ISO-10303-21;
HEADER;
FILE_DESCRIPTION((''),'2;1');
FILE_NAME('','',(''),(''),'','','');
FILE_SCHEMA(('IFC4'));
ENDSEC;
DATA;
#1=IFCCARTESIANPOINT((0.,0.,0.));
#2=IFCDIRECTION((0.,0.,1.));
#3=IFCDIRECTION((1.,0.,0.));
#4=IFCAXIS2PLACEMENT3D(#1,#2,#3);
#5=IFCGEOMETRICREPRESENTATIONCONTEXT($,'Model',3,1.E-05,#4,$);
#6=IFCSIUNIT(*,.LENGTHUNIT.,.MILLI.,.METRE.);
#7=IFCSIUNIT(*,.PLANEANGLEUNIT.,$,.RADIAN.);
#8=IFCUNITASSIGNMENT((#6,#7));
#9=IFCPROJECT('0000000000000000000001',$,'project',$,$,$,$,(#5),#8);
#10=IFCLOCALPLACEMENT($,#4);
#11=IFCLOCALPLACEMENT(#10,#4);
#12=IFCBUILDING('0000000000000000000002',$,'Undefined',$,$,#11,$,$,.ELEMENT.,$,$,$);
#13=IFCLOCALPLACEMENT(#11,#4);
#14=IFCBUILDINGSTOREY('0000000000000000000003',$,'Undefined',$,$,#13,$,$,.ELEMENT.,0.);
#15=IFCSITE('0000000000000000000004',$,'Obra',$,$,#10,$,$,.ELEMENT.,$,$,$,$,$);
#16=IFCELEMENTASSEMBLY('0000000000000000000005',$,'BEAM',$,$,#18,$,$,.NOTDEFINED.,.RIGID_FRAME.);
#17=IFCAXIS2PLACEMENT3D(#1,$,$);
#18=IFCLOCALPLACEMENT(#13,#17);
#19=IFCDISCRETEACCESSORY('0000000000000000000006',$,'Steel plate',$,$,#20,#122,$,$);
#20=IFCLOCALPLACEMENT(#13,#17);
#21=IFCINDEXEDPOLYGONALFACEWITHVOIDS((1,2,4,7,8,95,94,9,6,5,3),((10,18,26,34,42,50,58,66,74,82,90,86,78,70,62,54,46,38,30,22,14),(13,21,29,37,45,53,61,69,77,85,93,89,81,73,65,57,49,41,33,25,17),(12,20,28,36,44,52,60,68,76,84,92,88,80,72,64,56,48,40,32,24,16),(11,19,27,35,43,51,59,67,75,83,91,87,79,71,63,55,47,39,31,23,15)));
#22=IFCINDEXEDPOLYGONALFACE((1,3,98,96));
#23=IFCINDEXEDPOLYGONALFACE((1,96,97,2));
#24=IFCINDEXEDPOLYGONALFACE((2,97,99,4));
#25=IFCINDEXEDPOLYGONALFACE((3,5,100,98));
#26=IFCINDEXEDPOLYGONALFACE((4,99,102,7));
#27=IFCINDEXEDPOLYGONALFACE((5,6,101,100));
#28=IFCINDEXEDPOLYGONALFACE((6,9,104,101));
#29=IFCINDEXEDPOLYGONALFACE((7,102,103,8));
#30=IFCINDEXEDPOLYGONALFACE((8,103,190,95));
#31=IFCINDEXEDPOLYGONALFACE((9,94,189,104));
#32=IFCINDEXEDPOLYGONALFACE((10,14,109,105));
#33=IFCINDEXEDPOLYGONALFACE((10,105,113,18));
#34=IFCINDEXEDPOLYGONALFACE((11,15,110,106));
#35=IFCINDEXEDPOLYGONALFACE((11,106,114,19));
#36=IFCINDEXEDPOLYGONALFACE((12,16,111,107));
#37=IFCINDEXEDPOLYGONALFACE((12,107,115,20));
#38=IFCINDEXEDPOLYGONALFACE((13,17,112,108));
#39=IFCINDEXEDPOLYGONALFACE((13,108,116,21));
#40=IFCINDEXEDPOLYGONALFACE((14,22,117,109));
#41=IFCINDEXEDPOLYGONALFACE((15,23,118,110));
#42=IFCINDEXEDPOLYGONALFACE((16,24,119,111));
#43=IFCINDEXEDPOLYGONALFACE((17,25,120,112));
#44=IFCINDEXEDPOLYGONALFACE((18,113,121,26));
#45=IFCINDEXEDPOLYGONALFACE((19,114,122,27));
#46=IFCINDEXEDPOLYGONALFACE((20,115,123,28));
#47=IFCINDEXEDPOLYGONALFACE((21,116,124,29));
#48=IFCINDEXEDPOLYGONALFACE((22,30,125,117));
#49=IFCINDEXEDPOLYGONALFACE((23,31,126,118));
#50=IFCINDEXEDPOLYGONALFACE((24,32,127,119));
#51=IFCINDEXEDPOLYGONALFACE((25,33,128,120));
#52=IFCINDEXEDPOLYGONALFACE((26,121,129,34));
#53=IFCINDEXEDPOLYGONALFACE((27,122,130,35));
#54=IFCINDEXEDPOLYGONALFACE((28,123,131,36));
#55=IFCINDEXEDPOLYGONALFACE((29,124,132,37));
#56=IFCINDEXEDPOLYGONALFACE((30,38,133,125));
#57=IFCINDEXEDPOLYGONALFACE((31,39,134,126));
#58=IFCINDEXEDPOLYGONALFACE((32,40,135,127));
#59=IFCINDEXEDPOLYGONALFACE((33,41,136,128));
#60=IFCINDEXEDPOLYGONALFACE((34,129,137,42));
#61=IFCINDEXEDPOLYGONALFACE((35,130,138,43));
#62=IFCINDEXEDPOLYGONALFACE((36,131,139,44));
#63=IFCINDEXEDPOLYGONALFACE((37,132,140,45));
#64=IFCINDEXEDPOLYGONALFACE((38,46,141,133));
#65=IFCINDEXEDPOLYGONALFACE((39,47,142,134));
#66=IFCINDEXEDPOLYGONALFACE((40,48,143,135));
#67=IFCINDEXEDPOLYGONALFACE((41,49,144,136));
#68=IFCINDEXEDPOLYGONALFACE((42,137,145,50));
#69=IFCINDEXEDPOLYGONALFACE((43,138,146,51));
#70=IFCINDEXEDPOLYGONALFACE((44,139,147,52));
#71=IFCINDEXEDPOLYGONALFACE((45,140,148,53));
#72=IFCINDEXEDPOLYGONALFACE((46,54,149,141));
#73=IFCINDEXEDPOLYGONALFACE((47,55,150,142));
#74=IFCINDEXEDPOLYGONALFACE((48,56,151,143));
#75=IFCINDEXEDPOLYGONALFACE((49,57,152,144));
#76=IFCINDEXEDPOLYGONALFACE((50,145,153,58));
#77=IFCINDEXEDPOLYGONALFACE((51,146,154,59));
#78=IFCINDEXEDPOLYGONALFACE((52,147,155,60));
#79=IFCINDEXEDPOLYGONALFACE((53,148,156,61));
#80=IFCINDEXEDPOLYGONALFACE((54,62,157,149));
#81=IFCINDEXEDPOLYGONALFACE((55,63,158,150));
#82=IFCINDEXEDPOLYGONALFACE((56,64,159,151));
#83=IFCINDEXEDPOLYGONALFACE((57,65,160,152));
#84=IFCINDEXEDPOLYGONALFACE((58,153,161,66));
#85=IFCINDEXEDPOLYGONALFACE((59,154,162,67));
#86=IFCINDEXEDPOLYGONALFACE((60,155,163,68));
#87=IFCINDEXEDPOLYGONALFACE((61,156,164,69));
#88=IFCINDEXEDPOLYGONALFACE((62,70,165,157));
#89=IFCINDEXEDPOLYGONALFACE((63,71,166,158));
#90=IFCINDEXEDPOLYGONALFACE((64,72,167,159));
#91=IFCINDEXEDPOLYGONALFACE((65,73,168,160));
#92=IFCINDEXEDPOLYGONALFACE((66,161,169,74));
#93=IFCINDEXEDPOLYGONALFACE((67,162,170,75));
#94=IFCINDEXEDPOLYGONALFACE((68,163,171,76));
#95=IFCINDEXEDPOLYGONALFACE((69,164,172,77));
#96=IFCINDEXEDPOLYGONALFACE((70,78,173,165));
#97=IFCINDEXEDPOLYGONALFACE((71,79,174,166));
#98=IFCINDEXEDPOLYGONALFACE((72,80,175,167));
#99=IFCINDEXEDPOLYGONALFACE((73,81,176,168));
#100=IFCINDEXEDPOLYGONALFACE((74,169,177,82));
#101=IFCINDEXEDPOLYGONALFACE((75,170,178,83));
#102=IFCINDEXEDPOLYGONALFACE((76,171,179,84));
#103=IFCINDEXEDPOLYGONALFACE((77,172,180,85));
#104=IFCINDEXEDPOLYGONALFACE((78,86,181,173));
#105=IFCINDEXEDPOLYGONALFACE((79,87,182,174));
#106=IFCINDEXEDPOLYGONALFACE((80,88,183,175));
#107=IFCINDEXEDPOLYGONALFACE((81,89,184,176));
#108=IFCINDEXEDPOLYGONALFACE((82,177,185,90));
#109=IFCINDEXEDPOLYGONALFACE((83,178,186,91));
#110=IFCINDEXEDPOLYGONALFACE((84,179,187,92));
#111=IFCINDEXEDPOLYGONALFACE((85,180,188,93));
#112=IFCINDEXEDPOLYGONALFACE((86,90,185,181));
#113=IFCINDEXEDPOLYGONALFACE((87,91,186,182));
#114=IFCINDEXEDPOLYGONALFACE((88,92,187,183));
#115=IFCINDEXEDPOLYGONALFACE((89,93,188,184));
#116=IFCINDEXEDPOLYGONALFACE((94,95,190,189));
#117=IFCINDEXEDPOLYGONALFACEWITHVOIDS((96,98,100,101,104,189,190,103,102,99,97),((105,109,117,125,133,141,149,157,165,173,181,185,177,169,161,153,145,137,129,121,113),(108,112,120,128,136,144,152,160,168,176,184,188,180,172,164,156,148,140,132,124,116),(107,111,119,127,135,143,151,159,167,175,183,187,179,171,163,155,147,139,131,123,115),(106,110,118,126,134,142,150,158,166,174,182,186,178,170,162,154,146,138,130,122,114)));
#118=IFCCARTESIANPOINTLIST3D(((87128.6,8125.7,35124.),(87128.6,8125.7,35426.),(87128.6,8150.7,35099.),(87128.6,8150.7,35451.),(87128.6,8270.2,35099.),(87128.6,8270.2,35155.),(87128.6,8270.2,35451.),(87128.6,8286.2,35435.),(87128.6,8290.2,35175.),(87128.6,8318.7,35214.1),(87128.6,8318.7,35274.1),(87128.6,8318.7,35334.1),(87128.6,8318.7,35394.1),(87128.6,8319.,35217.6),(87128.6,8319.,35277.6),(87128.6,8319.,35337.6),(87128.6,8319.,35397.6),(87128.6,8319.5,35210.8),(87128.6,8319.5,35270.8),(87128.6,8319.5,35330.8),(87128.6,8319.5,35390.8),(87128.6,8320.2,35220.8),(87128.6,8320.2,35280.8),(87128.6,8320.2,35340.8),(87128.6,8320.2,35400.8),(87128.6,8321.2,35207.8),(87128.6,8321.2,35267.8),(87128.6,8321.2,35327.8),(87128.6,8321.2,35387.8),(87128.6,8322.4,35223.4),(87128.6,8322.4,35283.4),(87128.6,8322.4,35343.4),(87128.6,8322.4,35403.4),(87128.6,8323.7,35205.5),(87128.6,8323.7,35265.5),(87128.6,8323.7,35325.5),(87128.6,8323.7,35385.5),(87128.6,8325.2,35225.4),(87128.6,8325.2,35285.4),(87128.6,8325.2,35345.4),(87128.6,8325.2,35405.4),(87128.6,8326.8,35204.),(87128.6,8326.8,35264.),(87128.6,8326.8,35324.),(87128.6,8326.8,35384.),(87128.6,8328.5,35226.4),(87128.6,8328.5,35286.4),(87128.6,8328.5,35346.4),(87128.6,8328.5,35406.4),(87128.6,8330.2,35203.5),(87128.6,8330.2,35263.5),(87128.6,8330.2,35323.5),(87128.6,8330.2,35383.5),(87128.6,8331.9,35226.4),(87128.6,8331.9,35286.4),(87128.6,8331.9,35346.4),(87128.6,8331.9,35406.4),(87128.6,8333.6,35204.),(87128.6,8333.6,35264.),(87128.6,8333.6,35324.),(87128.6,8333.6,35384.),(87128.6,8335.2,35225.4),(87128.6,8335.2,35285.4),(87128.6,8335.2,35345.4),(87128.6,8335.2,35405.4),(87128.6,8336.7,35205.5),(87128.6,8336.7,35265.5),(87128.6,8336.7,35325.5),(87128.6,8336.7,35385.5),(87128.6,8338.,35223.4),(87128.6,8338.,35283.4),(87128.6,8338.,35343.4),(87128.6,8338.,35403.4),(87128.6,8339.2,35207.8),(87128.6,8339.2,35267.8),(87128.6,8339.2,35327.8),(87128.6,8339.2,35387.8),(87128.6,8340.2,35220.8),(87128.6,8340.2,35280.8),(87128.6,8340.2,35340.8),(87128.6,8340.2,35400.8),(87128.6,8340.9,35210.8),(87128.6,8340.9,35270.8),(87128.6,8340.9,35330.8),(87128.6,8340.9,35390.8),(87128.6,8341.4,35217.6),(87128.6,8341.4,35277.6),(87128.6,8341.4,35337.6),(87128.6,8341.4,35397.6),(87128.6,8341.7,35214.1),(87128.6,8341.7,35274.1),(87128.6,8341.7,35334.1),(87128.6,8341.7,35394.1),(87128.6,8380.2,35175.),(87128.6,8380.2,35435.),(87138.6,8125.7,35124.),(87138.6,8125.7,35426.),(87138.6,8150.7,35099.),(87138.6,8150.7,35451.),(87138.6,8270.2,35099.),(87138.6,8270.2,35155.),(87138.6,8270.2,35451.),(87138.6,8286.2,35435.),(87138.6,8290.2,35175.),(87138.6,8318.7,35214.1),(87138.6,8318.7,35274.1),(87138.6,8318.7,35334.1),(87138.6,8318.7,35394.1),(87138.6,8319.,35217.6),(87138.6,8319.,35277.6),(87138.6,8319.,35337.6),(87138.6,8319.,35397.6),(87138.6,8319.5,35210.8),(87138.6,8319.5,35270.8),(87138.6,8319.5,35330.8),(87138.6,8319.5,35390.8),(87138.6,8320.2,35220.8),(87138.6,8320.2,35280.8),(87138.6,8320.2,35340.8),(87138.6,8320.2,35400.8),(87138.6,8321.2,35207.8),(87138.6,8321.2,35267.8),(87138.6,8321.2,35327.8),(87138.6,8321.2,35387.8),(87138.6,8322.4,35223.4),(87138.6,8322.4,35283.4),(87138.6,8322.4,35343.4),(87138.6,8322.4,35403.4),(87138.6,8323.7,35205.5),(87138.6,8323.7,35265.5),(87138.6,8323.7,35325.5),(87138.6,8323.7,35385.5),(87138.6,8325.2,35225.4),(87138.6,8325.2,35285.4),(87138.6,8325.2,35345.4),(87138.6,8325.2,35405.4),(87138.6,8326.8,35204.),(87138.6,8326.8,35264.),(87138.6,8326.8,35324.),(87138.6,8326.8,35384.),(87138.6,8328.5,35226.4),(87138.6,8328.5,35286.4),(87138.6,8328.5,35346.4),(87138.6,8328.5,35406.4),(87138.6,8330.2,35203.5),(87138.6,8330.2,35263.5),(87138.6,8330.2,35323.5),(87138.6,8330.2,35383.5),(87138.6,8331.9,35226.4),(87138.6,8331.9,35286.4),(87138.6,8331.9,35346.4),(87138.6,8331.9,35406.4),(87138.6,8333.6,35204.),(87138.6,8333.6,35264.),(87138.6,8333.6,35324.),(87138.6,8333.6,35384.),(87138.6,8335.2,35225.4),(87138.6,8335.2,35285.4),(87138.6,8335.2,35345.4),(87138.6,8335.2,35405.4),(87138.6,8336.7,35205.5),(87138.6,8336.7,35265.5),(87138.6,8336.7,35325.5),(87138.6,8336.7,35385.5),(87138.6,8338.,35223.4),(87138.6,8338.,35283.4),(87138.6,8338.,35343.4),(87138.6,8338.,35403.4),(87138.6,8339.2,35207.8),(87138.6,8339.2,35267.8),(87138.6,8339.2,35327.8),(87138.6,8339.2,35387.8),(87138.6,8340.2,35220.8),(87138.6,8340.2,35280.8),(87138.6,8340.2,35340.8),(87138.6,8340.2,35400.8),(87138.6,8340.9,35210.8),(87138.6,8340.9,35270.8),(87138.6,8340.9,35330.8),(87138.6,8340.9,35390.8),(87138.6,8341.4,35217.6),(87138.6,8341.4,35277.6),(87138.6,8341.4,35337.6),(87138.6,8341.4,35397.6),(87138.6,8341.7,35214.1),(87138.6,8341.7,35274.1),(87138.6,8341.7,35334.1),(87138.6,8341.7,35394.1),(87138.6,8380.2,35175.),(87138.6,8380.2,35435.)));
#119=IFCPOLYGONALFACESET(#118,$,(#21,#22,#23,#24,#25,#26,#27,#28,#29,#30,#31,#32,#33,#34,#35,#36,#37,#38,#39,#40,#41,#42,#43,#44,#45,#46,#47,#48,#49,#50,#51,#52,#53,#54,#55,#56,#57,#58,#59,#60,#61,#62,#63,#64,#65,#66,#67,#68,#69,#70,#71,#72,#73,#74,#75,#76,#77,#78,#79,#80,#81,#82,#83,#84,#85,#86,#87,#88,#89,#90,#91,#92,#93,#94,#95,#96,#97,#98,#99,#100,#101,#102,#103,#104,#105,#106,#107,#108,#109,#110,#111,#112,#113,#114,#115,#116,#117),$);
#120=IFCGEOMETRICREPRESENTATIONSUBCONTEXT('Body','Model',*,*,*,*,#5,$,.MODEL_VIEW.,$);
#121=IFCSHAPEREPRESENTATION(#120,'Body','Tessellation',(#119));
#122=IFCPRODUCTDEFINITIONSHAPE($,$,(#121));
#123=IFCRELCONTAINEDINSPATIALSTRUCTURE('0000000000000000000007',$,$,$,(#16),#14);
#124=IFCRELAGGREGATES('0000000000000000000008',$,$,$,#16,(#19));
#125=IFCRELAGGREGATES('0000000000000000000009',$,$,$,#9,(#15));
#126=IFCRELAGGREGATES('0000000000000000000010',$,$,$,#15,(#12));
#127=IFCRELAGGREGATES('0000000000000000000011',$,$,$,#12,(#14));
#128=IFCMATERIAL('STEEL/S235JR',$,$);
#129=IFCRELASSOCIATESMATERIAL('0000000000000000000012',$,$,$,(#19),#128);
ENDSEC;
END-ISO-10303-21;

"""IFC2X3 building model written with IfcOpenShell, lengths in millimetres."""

from ifc_helpers import new_model, si_unit, frame, origin_with_axes, origin_2d_with_axis, place, context, subcontext, project, spatial, polyline, circle, outline, extrude, source, transform, mapped, material, element, aggregate, save


model = new_model("IFC2X3")

# Units and contexts
model_context = context("Model", 3, precision=1e-05, world=origin_with_axes())
body_context = subcontext(model_context, "Body", "Model", "MODEL_VIEW")
ifc_project = project(units=[si_unit("LENGTHUNIT", "METRE", prefix="MILLI"), si_unit("PLANEANGLEUNIT", "RADIAN")], contexts=[model_context])

# Site, building, storey
site_placement = place(None, origin_with_axes())
site = spatial("IfcSite", under=ifc_project, at=site_placement, Name="Obra", CompositionType="ELEMENT")
building_placement = place(site_placement, origin_with_axes())
building = spatial("IfcBuilding", under=site, at=building_placement, Name="Undefined", CompositionType="ELEMENT")
storey_placement = place(building_placement, origin_with_axes())
storey = spatial("IfcBuildingStorey", under=building, at=storey_placement, Name="Undefined", CompositionType="ELEMENT", Elevation=0.0)

# Shared definitions
ifc_material_1 = material(Name="STEEL/S235JR")

# Element assembly
assembly_1_placement = place(storey_placement, origin_with_axes())
assembly_1 = element("IfcElementAssembly", 1, at=assembly_1_placement, inside=storey, Name="BEAM", AssemblyPlace="NOTDEFINED", PredefinedType="RIGID_FRAME")

# Discrete accessory, opening
discrete_accessory_1_placement = place(assembly_1_placement, frame((87133.6, 8125.7, 35124.0), z_axis=(1.0, 0.0, 0.0), x_axis=(0.000001, 0.707107, -0.707107)))
discrete_accessory_1 = element("IfcDiscreteAccessory", 2, at=discrete_accessory_1_placement, material=ifc_material_1, Name="Steel plate", context=body_context, shape_type="SweptSolid", body=[
    extrude(outline(polyline([(0.0, 0.0), (35.4, 0.0), (119.9, 84.5), (80.3, 124.1), (80.3, 152.4), (143.9, 216.0), (-40.0, 399.9), (-106.4, 333.4), (-129.0, 333.4), (-129.0, 333.4), (-213.5, 248.9), (-213.5, 213.5), (0.0, 0.0)])), frame((0.0, 0.0, -5.0), z_axis=(0.0, 0.0, 1.0), x_axis=(1.0, 0.0, 0.0)), (0.0, 0.0, 1.0), 10.0),
])
shared_shape_1 = source(origin_with_axes(), body_context, "Body", "SweptSolid", [
    extrude(circle(Radius=11.5, at=origin_2d_with_axis()), frame((0.0, -13.8, 0.0), z_axis=(0.0, 1.0, 0.0), x_axis=(1.0, 0.0, 0.0)), (0.0, 0.0, 1.0), 10.2),
])
opening_1_placement = place(assembly_1_placement, frame((87124.9, 8280.2, 35435.0), z_axis=(0.0, 1.0, 0.0), x_axis=(0.0, 0.0, -1.0)))
element("IfcOpeningElement", 3, at=opening_1_placement, cuts=discrete_accessory_1, ObjectType="Opening", context=body_context, shape_type="MappedRepresentation", body=[
    mapped(shared_shape_1, transform((40.0, 0.0, 50.0))),
    mapped(shared_shape_1, transform((100.0, 0.0, 50.0))),
    mapped(shared_shape_1, transform((160.0, 0.0, 50.0))),
    mapped(shared_shape_1, transform((220.0, 0.0, 50.0))),
])
aggregate(assembly_1, [discrete_accessory_1])

save(model, "model.ifc")
